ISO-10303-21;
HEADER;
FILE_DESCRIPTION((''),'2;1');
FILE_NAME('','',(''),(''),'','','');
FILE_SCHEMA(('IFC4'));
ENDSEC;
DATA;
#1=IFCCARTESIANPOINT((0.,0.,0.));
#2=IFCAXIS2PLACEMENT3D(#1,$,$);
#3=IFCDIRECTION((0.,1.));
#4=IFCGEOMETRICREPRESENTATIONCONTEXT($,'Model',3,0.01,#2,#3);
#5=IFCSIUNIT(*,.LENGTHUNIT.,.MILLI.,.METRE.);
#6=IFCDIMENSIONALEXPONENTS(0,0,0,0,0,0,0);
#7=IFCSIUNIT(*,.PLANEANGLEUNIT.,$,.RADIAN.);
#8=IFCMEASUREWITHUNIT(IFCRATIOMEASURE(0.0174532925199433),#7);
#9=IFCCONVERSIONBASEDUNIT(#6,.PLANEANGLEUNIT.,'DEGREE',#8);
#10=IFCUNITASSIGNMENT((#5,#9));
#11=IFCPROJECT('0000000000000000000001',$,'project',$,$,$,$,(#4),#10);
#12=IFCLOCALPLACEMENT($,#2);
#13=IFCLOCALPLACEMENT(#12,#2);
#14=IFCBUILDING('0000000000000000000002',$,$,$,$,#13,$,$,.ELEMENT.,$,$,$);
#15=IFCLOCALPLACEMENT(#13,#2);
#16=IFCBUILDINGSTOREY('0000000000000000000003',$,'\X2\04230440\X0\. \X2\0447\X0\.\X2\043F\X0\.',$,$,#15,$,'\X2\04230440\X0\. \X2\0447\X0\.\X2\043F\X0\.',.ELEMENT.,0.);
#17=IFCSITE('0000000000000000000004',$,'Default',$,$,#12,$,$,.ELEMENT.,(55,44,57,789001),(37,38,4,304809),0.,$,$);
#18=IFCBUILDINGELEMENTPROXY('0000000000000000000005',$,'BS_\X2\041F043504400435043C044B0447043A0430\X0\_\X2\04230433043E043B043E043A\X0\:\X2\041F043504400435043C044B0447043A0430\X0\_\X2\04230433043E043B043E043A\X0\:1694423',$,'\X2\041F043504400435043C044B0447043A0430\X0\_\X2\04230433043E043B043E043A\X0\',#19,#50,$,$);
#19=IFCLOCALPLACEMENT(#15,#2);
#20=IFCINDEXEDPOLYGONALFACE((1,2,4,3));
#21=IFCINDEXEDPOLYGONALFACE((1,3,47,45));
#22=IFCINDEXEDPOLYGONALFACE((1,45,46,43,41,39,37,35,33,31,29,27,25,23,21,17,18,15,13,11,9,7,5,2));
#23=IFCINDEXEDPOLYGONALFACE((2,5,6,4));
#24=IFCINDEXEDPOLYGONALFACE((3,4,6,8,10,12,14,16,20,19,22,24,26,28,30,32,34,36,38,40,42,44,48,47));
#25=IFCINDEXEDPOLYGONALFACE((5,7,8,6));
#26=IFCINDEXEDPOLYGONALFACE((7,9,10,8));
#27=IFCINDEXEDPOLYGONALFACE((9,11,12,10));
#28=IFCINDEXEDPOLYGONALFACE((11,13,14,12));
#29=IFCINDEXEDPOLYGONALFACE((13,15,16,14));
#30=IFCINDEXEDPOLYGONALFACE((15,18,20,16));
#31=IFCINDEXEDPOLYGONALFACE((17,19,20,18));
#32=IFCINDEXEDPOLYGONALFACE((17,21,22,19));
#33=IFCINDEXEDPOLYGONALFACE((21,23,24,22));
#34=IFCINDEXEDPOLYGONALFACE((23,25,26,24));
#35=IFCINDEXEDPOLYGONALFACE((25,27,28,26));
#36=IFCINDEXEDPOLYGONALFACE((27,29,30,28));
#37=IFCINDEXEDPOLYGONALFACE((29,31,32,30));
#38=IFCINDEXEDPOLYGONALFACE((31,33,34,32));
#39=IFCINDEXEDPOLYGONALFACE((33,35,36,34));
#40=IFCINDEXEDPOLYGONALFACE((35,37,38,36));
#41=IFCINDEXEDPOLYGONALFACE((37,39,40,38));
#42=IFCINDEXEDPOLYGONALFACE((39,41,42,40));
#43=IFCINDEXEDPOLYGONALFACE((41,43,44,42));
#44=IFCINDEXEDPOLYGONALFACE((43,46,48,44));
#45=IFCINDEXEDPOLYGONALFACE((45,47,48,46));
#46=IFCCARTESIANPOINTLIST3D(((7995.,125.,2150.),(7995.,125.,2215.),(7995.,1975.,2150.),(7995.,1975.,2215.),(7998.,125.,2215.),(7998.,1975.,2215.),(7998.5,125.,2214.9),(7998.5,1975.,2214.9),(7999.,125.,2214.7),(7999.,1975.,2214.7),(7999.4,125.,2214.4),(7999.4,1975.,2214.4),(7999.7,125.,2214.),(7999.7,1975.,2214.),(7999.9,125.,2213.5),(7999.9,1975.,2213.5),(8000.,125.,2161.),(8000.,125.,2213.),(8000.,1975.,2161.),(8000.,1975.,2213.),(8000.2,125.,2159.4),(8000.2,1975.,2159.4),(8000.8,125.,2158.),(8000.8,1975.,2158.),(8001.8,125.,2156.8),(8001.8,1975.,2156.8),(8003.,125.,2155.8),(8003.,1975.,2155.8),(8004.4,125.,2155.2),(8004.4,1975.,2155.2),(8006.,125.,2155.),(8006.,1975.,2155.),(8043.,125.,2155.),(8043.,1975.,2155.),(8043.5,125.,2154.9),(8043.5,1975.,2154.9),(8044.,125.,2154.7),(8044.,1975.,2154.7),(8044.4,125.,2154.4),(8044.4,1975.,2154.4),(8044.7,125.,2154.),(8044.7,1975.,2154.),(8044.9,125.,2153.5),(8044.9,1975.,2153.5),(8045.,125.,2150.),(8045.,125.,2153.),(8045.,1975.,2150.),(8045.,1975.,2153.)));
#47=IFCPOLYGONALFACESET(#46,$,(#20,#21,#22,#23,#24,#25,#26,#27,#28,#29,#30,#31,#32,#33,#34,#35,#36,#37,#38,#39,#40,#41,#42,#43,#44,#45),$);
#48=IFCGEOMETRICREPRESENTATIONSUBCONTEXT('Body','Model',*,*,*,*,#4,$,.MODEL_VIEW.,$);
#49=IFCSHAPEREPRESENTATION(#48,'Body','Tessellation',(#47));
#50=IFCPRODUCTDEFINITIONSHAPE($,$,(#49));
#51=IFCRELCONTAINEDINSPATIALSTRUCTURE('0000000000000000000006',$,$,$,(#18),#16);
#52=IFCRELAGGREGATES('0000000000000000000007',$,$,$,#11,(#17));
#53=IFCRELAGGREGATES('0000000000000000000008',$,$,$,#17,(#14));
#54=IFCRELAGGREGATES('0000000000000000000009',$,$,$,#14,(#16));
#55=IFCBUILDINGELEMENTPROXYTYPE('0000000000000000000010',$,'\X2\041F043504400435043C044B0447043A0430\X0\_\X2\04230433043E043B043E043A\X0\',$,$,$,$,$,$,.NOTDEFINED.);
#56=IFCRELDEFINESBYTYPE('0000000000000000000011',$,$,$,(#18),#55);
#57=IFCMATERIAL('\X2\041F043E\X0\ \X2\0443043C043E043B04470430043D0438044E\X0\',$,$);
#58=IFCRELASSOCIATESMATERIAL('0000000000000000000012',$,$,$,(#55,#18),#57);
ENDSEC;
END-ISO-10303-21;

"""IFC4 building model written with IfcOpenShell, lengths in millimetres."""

from ifc_helpers import new_model, entity, si_unit, converted_unit, direction, frame, frame_2d, origin, place, context, subcontext, project, spatial, polyline, circle_curve, parameter, trimmed, segment, composite_curve, outline, extrude, source, transform, mapped, material, type_object, type_shapes, element, save


model = new_model("IFC4")

# Units and contexts
model_context = context("Model", 3, precision=0.01, world=origin(), true_north=direction((0.0, 1.0)))
body_context = subcontext(model_context, "Body", "Model", "MODEL_VIEW")
ifc_project = project(units=[si_unit("LENGTHUNIT", "METRE", prefix="MILLI"), converted_unit("PLANEANGLEUNIT", "DEGREE", entity("IfcRatioMeasure", 0.0174532925199433), si_unit("PLANEANGLEUNIT", "RADIAN"), dimensions=[0, 0, 0, 0, 0, 0, 0])], contexts=[model_context])

# Site, building, storey
site_placement = place(None, origin())
site = spatial("IfcSite", under=ifc_project, at=site_placement, Name="Default", CompositionType="ELEMENT", RefLatitude=(55, 44, 57, 789001), RefLongitude=(37, 38, 4, 304809), RefElevation=0.0)
building_placement = place(site_placement, origin())
building = spatial("IfcBuilding", under=site, at=building_placement, CompositionType="ELEMENT")
storey_placement = place(building_placement, origin())
storey = spatial("IfcBuildingStorey", under=building, at=storey_placement, Name="Ур. ч.п.", LongName="Ур. ч.п.", CompositionType="ELEMENT", Elevation=0.0)

# Building element proxy
ifc_material_1 = material(Name="По умолчанию")
building_element_proxy_type_1 = type_object("IfcBuildingElementProxyType", Name="Перемычка_Уголок", material=ifc_material_1)
shared_shape_1 = source(origin(), body_context, "Body", "SweptSolid", [
    extrude(outline(composite_curve([segment(polyline([(-24.1, -19.1), (40.9, -19.1)]), True, "CONTINUOUS"), segment(polyline([(40.9, -19.1), (40.9, -16.1)]), True, "CONTINUOUS"), segment(trimmed(circle_curve(frame_2d((38.9, -16.1), x_axis=(0.0, 1.0)), 2.0), [parameter(270.0)], [parameter(0.0)], True, "PARAMETER"), True, "CONTINUOUS"), segment(polyline([(38.9, -14.1), (-13.1, -14.1)]), True, "CONTINUOUS"), segment(trimmed(circle_curve(frame_2d((-13.1, -8.1), x_axis=(0.0, 1.0)), 6.0), [parameter(90.0)], [parameter(180.0)], True, "PARAMETER"), False, "CONTINUOUS"), segment(polyline([(-19.1, -8.1), (-19.1, 28.9)]), True, "CONTINUOUS"), segment(trimmed(circle_curve(frame_2d((-21.1, 28.9), x_axis=(0.0, 1.0)), 2.0), [parameter(270.0)], [parameter(0.0)], True, "PARAMETER"), True, "CONTINUOUS"), segment(polyline([(-21.1, 30.9), (-24.1, 30.9)]), True, "CONTINUOUS"), segment(polyline([(-24.1, 30.9), (-24.1, -19.1)]), True, "CONTINUOUS")], self_intersect=False)), frame((0.0, 32.5, 24.1), z_axis=(1.0, 0.0, 0.0), x_axis=(0.0, 0.0, 1.0)), (0.0, 0.0, 1.0), 1850.0),
])
type_shapes(building_element_proxy_type_1, [shared_shape_1])
for number, where, z_axis, x_axis, name in (
    (1, (8046.6, 125.0, 2150.0), (0.0, 0.0, 1.0), (0.0, 1.0, 0.0), "BS_Перемычка_Уголок:Перемычка_Уголок:1694423"),
):
    element("IfcBuildingElementProxy", number, at=place(storey_placement, frame(where, z_axis=z_axis, x_axis=x_axis)), inside=storey, type_object=building_element_proxy_type_1, material=ifc_material_1, Name=name, ObjectType="Перемычка_Уголок", context=body_context, shape_type="MappedRepresentation", body=[
        mapped(shared_shape_1, transform((0.0, 0.0, 0.0), scale=1.0)),
    ])

save(model, "model.ifc")
